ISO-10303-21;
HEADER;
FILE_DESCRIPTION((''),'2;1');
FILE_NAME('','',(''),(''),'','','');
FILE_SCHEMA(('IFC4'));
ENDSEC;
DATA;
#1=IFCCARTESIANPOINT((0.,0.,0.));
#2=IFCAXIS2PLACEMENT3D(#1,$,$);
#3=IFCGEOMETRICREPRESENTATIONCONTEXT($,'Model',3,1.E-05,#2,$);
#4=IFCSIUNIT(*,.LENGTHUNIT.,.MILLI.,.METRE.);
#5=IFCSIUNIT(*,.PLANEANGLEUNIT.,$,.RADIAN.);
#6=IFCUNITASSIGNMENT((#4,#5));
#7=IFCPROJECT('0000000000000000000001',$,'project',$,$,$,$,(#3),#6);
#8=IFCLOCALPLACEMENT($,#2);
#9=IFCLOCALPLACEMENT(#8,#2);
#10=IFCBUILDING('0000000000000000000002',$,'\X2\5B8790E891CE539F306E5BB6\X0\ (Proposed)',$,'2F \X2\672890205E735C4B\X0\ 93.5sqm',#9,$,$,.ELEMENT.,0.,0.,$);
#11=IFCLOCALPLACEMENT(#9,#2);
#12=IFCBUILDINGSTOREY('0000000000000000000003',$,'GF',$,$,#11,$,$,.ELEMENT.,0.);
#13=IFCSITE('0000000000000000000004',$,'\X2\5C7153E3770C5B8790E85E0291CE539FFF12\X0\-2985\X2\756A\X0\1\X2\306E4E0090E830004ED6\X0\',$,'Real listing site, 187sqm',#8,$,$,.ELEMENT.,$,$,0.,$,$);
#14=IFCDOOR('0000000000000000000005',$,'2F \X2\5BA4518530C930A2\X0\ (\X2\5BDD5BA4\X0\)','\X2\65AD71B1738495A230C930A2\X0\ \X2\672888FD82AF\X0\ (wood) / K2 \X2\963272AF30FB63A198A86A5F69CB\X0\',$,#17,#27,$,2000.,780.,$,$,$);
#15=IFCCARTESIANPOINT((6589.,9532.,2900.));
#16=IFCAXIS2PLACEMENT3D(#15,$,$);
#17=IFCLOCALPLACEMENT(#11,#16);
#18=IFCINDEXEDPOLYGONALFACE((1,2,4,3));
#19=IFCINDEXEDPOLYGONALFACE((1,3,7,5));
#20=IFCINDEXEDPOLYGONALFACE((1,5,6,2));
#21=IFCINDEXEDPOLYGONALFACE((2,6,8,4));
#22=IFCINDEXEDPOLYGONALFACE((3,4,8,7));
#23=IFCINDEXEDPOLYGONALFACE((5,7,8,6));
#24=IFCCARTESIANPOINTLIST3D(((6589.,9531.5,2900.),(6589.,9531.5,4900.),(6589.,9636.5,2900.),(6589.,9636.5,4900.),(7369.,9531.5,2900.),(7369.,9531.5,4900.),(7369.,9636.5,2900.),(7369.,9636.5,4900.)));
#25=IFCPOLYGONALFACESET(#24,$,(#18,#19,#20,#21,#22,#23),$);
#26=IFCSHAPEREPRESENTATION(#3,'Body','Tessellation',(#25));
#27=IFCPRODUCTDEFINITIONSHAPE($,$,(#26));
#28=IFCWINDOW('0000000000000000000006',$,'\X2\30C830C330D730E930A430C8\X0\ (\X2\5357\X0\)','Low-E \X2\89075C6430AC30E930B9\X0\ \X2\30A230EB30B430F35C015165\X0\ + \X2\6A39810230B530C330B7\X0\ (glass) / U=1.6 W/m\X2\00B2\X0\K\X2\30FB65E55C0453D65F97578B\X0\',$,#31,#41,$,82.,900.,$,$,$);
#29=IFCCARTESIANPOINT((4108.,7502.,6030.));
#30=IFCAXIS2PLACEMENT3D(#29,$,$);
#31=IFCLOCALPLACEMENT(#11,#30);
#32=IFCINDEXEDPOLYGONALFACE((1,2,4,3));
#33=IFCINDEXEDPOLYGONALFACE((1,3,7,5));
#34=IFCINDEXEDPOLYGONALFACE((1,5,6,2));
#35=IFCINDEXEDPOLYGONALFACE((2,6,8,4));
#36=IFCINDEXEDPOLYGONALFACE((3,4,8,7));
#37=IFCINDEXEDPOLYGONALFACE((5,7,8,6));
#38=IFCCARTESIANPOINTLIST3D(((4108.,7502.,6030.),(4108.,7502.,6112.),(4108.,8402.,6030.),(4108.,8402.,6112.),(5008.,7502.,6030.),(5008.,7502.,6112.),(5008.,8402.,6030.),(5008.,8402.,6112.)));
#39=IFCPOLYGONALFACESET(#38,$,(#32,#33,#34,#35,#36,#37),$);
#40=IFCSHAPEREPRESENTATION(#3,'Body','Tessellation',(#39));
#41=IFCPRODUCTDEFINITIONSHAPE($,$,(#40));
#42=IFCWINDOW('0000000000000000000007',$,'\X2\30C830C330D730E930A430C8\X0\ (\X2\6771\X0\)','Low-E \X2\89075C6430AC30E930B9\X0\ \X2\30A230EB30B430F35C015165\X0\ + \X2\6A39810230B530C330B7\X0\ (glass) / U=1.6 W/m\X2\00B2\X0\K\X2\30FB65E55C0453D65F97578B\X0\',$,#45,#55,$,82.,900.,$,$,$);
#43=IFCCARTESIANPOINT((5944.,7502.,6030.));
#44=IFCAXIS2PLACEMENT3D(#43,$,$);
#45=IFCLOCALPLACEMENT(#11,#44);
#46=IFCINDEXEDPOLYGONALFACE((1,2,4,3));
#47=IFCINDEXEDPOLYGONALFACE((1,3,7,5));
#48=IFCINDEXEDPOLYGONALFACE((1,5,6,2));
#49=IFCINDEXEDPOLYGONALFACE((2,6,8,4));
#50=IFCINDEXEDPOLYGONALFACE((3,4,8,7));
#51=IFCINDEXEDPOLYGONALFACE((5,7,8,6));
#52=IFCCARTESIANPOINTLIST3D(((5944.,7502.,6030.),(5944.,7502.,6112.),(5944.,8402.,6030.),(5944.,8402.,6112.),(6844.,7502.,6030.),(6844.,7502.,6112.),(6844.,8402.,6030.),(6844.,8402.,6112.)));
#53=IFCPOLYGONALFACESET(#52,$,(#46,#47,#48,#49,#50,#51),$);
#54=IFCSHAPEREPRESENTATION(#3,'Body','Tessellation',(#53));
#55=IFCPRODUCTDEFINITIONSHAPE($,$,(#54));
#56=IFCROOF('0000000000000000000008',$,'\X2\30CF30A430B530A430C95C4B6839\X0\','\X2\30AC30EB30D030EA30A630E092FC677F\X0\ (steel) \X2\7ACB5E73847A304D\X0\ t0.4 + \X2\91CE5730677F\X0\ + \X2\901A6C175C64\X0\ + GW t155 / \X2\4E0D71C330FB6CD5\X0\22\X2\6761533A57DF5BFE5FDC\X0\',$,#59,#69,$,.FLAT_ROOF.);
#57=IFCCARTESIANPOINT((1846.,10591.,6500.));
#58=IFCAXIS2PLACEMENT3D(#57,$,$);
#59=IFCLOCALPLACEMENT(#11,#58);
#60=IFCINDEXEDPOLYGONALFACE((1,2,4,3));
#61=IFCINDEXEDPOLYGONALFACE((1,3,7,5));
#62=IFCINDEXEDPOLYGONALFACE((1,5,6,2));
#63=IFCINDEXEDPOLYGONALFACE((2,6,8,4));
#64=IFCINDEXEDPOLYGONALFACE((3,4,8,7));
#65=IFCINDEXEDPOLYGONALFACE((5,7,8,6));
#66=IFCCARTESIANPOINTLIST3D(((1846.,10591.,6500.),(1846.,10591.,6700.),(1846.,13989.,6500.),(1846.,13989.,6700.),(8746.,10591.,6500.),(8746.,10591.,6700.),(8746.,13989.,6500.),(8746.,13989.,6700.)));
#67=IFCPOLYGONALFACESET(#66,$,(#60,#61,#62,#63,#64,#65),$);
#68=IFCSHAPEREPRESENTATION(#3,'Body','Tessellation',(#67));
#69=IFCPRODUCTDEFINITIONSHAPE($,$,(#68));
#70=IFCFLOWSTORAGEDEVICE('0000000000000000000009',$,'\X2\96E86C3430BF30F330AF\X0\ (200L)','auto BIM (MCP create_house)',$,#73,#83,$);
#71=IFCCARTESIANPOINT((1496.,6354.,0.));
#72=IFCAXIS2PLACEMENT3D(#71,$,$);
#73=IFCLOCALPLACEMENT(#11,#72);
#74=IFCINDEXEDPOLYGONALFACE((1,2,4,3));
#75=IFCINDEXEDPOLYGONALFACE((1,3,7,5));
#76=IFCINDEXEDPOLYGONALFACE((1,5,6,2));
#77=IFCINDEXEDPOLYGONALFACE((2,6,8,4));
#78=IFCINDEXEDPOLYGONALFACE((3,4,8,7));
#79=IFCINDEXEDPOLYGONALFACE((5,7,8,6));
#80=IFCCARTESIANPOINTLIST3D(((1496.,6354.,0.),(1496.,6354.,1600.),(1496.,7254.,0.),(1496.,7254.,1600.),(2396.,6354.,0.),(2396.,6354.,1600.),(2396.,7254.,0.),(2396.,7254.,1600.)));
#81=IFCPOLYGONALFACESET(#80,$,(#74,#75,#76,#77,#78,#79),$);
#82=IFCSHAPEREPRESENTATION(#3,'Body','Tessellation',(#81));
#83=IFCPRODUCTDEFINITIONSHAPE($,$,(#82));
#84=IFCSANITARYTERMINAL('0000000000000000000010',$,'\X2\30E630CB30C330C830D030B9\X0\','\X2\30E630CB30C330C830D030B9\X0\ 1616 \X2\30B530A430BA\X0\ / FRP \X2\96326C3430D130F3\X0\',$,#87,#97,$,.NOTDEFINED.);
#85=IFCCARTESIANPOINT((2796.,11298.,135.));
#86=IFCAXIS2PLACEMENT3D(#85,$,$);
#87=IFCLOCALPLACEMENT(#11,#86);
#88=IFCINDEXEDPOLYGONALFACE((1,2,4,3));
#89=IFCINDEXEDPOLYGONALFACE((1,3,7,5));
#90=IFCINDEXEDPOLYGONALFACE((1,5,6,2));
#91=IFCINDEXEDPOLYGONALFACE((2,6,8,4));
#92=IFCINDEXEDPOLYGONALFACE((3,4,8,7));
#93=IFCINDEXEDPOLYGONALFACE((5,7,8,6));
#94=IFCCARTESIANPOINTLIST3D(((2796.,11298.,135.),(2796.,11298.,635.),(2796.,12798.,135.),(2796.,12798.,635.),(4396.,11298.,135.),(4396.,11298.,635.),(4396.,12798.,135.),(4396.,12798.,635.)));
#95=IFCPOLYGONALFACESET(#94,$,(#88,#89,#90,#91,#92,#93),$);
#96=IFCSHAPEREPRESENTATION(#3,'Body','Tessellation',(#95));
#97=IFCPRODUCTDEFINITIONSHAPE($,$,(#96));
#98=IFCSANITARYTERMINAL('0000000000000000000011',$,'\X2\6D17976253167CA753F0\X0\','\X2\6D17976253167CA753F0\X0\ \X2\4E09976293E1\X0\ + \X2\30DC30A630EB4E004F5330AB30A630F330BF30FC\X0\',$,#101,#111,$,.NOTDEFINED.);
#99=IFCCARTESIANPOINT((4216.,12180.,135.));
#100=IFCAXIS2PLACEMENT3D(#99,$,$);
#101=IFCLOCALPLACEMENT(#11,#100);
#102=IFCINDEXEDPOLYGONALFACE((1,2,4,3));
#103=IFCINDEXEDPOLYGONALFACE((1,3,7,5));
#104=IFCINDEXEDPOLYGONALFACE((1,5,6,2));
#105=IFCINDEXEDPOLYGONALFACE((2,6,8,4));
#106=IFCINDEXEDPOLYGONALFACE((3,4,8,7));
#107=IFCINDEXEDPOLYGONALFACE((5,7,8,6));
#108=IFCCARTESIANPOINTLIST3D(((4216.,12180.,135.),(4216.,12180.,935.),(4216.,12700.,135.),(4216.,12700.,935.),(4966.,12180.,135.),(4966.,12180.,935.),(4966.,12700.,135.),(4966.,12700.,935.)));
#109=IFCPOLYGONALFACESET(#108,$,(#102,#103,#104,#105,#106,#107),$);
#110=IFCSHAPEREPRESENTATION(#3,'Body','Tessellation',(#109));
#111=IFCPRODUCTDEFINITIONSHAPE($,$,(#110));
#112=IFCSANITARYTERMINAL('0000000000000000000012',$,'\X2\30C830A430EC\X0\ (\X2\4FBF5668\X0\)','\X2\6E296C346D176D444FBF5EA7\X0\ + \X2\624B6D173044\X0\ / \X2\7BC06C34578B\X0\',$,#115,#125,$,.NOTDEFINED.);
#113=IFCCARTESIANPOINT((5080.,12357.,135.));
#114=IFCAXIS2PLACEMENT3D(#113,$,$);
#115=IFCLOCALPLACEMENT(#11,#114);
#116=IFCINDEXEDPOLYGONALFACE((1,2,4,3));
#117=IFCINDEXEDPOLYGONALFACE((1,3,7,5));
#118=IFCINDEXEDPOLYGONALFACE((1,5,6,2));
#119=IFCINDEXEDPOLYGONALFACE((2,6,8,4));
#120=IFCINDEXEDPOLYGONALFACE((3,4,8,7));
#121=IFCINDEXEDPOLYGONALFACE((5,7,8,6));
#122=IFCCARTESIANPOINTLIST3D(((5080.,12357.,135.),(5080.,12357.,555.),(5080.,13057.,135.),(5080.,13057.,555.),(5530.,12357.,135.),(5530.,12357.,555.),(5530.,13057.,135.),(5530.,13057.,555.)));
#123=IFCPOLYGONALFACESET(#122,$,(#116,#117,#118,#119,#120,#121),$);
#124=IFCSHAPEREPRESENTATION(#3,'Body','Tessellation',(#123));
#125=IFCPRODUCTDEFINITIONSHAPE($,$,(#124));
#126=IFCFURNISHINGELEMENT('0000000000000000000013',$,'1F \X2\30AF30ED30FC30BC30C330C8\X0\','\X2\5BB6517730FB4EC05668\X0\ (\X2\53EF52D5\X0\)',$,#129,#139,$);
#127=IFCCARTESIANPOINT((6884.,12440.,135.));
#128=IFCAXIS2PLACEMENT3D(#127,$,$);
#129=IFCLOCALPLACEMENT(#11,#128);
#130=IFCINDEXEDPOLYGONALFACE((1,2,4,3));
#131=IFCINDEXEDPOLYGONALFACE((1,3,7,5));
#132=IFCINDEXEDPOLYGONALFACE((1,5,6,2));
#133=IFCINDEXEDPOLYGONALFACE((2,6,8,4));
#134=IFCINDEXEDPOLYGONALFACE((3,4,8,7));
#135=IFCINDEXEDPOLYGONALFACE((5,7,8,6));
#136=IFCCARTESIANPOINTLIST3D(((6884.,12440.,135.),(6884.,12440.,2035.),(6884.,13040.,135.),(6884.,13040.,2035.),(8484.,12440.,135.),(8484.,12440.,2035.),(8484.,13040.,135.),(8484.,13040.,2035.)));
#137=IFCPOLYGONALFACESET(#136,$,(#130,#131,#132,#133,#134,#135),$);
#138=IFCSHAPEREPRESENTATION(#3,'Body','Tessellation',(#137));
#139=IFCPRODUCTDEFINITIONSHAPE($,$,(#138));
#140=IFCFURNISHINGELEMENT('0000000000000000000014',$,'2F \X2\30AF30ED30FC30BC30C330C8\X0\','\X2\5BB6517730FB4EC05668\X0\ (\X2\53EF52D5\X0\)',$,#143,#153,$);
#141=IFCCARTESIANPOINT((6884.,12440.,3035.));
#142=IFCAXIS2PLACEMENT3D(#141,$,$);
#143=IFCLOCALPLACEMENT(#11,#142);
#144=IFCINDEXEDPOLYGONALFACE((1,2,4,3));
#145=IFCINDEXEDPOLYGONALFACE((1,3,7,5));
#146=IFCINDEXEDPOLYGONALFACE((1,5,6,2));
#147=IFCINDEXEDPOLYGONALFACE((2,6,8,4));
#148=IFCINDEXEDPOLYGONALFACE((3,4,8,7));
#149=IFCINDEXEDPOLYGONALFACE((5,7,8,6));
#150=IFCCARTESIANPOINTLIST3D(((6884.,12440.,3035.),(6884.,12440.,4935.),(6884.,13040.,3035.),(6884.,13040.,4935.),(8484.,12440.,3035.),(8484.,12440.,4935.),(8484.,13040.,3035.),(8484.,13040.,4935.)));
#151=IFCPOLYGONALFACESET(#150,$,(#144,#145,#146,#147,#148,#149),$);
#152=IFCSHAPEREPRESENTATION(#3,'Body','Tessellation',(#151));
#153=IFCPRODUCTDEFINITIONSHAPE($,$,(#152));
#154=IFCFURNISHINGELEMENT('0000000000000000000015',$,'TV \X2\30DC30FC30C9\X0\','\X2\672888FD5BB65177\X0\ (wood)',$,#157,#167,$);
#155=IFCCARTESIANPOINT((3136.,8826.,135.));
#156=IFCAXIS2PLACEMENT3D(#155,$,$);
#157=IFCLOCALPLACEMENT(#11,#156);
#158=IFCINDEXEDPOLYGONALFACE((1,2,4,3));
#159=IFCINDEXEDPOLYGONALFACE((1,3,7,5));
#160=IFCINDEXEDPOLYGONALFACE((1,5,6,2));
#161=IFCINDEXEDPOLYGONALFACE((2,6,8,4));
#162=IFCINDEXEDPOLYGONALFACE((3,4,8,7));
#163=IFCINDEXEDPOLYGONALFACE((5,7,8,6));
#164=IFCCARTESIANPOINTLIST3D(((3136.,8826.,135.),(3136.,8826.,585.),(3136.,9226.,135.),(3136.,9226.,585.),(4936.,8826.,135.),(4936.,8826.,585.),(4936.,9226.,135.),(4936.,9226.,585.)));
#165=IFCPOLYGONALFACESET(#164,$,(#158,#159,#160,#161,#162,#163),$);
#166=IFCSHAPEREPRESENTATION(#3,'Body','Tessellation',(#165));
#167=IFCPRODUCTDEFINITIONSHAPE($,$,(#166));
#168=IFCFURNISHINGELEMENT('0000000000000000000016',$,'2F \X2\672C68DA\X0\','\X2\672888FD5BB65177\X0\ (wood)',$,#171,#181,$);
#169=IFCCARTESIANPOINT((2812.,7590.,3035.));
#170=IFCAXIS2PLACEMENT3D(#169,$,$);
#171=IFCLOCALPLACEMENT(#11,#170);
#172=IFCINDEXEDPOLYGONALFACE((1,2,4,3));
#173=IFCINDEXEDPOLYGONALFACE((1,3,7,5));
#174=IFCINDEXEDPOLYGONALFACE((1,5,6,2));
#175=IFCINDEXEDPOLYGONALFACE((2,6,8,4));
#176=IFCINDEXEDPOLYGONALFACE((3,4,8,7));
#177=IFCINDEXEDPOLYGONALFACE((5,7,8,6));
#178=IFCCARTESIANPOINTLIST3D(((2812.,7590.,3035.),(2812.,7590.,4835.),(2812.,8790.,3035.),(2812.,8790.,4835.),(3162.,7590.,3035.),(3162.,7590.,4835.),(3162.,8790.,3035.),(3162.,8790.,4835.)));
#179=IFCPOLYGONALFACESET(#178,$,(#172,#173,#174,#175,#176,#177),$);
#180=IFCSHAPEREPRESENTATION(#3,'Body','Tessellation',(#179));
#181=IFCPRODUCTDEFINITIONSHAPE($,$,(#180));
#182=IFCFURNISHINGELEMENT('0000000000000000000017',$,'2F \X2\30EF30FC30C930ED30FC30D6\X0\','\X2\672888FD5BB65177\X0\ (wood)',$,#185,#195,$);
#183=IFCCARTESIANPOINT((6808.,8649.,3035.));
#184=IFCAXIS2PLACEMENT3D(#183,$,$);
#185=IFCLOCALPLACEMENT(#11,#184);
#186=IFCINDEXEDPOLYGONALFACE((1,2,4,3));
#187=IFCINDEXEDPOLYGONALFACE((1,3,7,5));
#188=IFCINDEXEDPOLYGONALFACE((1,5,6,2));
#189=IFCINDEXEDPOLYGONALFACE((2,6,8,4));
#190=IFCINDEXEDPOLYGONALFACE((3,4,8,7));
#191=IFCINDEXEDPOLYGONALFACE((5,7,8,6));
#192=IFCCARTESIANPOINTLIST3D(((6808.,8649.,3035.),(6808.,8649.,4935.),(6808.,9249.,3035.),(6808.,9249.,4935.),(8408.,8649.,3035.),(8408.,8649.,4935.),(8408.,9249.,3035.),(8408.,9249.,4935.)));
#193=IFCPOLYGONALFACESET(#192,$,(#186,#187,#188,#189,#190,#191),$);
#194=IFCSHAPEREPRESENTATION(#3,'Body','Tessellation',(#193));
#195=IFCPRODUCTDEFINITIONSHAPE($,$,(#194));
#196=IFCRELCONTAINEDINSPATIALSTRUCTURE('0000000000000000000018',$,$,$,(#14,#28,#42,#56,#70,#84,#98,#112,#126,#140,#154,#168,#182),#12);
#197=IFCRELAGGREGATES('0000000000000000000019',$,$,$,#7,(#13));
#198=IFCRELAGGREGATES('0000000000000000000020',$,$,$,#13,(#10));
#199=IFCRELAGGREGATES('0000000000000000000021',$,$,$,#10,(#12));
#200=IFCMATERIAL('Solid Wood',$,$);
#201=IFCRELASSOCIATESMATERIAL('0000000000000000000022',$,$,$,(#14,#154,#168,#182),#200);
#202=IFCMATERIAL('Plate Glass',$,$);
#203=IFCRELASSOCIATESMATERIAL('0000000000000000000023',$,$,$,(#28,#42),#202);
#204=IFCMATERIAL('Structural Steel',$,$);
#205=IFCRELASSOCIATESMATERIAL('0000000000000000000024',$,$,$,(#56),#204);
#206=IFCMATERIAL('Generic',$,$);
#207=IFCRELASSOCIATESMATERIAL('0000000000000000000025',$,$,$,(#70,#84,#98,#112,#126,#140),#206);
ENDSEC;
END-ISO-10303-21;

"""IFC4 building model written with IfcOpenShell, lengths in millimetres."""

from ifc_helpers import new_model, si_unit, frame, frame_2d, origin, place, context, project, spatial, rectangle, extrude, material, element, save


model = new_model("IFC4")

# Units and contexts
model_context = context("Model", 3, precision=1e-05, world=origin())
ifc_project = project(units=[si_unit("LENGTHUNIT", "METRE", prefix="MILLI"), si_unit("PLANEANGLEUNIT", "RADIAN")], contexts=[model_context])

# Site, building, storey
site_placement = place(None, origin())
site = spatial("IfcSite", under=ifc_project, at=site_placement, Name="山口県宇部市野原２-2985番1の一部　他", ObjectType="Real listing site, 187sqm", CompositionType="ELEMENT", RefElevation=0.0)
building_placement = place(site_placement, origin())
building = spatial("IfcBuilding", under=site, at=building_placement, Name="宇部野原の家 (Proposed)", ObjectType="2F 木造平屋 93.5sqm", CompositionType="ELEMENT", ElevationOfRefHeight=0.0, ElevationOfTerrain=0.0)
storey_placement = place(building_placement, origin())
storey = spatial("IfcBuildingStorey", under=building, at=storey_placement, Name="GF", CompositionType="ELEMENT", Elevation=0.0)

# Shared definitions
ifc_material_1 = material(Name="Solid Wood")
ifc_material_2 = material(Name="Plate Glass")

# Door
door_1_placement = place(storey_placement, frame((6589.0, 9532.0, 2900.0)))
element("IfcDoor", 1, at=door_1_placement, inside=storey, material=ifc_material_1, Name="2F 室内ドア (寝室)", Description="断熱玄関ドア 木製芯 (wood) / K2 防犯・採風機構", OverallHeight=2000.0, OverallWidth=780.0, context=model_context, shape_type="SweptSolid", body=[
    extrude(rectangle(XDim=780.0, YDim=105.0, at=frame_2d((390.0, 52.0))), frame((6589.0, 9532.0, 2900.0)), (0.0, 0.0, 1.0), 2000.0),
])

# Windows
window_1_placement = place(storey_placement, frame((4108.0, 7502.0, 6030.0)))
element("IfcWindow", 2, at=window_1_placement, inside=storey, material=ifc_material_2, Name="トップライト (南)", Description="Low-E 複層ガラス アルゴン封入 + 樹脂サッシ (glass) / U=1.6 W/m²K・日射取得型", OverallHeight=82.0, OverallWidth=900.0, context=model_context, shape_type="SweptSolid", body=[
    extrude(rectangle(XDim=900.0, YDim=900.0, at=frame_2d((450.0, 450.0))), frame((4108.0, 7502.0, 6030.0)), (0.0, 0.0, 1.0), 82.0),
])
window_2_placement = place(storey_placement, frame((5944.0, 7502.0, 6030.0)))
element("IfcWindow", 3, at=window_2_placement, inside=storey, material=ifc_material_2, Name="トップライト (東)", Description="Low-E 複層ガラス アルゴン封入 + 樹脂サッシ (glass) / U=1.6 W/m²K・日射取得型", OverallHeight=82.0, OverallWidth=900.0, context=model_context, shape_type="SweptSolid", body=[
    extrude(rectangle(XDim=900.0, YDim=900.0, at=frame_2d((450.0, 450.0))), frame((5944.0, 7502.0, 6030.0)), (0.0, 0.0, 1.0), 82.0),
])

# Roof
ifc_material_3 = material(Name="Structural Steel")
roof_placement = place(storey_placement, frame((1846.0, 10591.0, 6500.0)))
element("IfcRoof", 4, at=roof_placement, inside=storey, material=ifc_material_3, Name="ハイサイド屋根", Description="ガルバリウム鋼板 (steel) 立平葺き t0.4 + 野地板 + 通気層 + GW t155 / 不燃・法22条区域対応", PredefinedType="FLAT_ROOF", context=model_context, shape_type="SweptSolid", body=[
    extrude(rectangle(XDim=6900.0, YDim=3398.0, at=frame_2d((3450.0, 1699.0))), frame((1846.0, 10591.0, 6500.0)), (0.0, 0.0, 1.0), 200.0),
])

# Flow storage device
ifc_material_4 = material(Name="Generic")
flow_storage_device_placement = place(storey_placement, frame((1496.0, 6354.0, 0.0)))
element("IfcFlowStorageDevice", 5, at=flow_storage_device_placement, inside=storey, material=ifc_material_4, Name="雨水タンク (200L)", Description="auto BIM (MCP create_house)", context=model_context, shape_type="SweptSolid", body=[
    extrude(rectangle(XDim=900.0, YDim=900.0, at=frame_2d((450.0, 450.0))), frame((1496.0, 6354.0, 0.0)), (0.0, 0.0, 1.0), 1600.0),
])

# Sanitary terminals
sanitary_terminal_1_placement = place(storey_placement, frame((2796.0, 11298.0, 135.0)))
element("IfcSanitaryTerminal", 6, at=sanitary_terminal_1_placement, inside=storey, material=ifc_material_4, Name="ユニットバス", Description="ユニットバス 1616 サイズ / FRP 防水パン", PredefinedType="NOTDEFINED", context=model_context, shape_type="SweptSolid", body=[
    extrude(rectangle(XDim=1600.0, YDim=1500.0, at=frame_2d((800.0, 750.0))), frame((2796.0, 11298.0, 135.0)), (0.0, 0.0, 1.0), 500.0),
])
sanitary_terminal_2_placement = place(storey_placement, frame((4216.0, 12180.0, 135.0)))
element("IfcSanitaryTerminal", 7, at=sanitary_terminal_2_placement, inside=storey, material=ifc_material_4, Name="洗面化粧台", Description="洗面化粧台 三面鏡 + ボウル一体カウンター", PredefinedType="NOTDEFINED", context=model_context, shape_type="SweptSolid", body=[
    extrude(rectangle(XDim=750.0, YDim=520.0, at=frame_2d((375.0, 260.0))), frame((4216.0, 12180.0, 135.0)), (0.0, 0.0, 1.0), 800.0),
])
sanitary_terminal_3_placement = place(storey_placement, frame((5080.0, 12357.0, 135.0)))
element("IfcSanitaryTerminal", 8, at=sanitary_terminal_3_placement, inside=storey, material=ifc_material_4, Name="トイレ (便器)", Description="温水洗浄便座 + 手洗い / 節水型", PredefinedType="NOTDEFINED", context=model_context, shape_type="SweptSolid", body=[
    extrude(rectangle(XDim=450.0, YDim=700.0, at=frame_2d((225.0, 350.0))), frame((5080.0, 12357.0, 135.0)), (0.0, 0.0, 1.0), 420.0),
])

# Furnishing elements
furnishing_1_placement = place(storey_placement, frame((6884.0, 12440.0, 135.0)))
element("IfcFurnishingElement", 9, at=furnishing_1_placement, inside=storey, material=ifc_material_4, Name="1F クローゼット", Description="家具・什器 (可動)", context=model_context, shape_type="SweptSolid", body=[
    extrude(rectangle(XDim=1600.0, YDim=600.0, at=frame_2d((800.0, 300.0))), frame((6884.0, 12440.0, 135.0)), (0.0, 0.0, 1.0), 1900.0),
])
furnishing_2_placement = place(storey_placement, frame((6884.0, 12440.0, 3035.0)))
element("IfcFurnishingElement", 10, at=furnishing_2_placement, inside=storey, material=ifc_material_4, Name="2F クローゼット", Description="家具・什器 (可動)", context=model_context, shape_type="SweptSolid", body=[
    extrude(rectangle(XDim=1600.0, YDim=600.0, at=frame_2d((800.0, 300.0))), frame((6884.0, 12440.0, 3035.0)), (0.0, 0.0, 1.0), 1900.0),
])
furnishing_3_placement = place(storey_placement, frame((3136.0, 8826.0, 135.0)))
element("IfcFurnishingElement", 11, at=furnishing_3_placement, inside=storey, material=ifc_material_1, Name="TV ボード", Description="木製家具 (wood)", context=model_context, shape_type="SweptSolid", body=[
    extrude(rectangle(XDim=1800.0, YDim=400.0, at=frame_2d((900.0, 200.0))), frame((3136.0, 8826.0, 135.0)), (0.0, 0.0, 1.0), 450.0),
])
furnishing_4_placement = place(storey_placement, frame((2812.0, 7590.0, 3035.0)))
element("IfcFurnishingElement", 12, at=furnishing_4_placement, inside=storey, material=ifc_material_1, Name="2F 本棚", Description="木製家具 (wood)", context=model_context, shape_type="SweptSolid", body=[
    extrude(rectangle(XDim=350.0, YDim=1200.0, at=frame_2d((175.0, 600.0))), frame((2812.0, 7590.0, 3035.0)), (0.0, 0.0, 1.0), 1800.0),
])
furnishing_5_placement = place(storey_placement, frame((6808.0, 8649.0, 3035.0)))
element("IfcFurnishingElement", 13, at=furnishing_5_placement, inside=storey, material=ifc_material_1, Name="2F ワードローブ", Description="木製家具 (wood)", context=model_context, shape_type="SweptSolid", body=[
    extrude(rectangle(XDim=1600.0, YDim=600.0, at=frame_2d((800.0, 300.0))), frame((6808.0, 8649.0, 3035.0)), (0.0, 0.0, 1.0), 1900.0),
])

save(model, "model.ifc")
